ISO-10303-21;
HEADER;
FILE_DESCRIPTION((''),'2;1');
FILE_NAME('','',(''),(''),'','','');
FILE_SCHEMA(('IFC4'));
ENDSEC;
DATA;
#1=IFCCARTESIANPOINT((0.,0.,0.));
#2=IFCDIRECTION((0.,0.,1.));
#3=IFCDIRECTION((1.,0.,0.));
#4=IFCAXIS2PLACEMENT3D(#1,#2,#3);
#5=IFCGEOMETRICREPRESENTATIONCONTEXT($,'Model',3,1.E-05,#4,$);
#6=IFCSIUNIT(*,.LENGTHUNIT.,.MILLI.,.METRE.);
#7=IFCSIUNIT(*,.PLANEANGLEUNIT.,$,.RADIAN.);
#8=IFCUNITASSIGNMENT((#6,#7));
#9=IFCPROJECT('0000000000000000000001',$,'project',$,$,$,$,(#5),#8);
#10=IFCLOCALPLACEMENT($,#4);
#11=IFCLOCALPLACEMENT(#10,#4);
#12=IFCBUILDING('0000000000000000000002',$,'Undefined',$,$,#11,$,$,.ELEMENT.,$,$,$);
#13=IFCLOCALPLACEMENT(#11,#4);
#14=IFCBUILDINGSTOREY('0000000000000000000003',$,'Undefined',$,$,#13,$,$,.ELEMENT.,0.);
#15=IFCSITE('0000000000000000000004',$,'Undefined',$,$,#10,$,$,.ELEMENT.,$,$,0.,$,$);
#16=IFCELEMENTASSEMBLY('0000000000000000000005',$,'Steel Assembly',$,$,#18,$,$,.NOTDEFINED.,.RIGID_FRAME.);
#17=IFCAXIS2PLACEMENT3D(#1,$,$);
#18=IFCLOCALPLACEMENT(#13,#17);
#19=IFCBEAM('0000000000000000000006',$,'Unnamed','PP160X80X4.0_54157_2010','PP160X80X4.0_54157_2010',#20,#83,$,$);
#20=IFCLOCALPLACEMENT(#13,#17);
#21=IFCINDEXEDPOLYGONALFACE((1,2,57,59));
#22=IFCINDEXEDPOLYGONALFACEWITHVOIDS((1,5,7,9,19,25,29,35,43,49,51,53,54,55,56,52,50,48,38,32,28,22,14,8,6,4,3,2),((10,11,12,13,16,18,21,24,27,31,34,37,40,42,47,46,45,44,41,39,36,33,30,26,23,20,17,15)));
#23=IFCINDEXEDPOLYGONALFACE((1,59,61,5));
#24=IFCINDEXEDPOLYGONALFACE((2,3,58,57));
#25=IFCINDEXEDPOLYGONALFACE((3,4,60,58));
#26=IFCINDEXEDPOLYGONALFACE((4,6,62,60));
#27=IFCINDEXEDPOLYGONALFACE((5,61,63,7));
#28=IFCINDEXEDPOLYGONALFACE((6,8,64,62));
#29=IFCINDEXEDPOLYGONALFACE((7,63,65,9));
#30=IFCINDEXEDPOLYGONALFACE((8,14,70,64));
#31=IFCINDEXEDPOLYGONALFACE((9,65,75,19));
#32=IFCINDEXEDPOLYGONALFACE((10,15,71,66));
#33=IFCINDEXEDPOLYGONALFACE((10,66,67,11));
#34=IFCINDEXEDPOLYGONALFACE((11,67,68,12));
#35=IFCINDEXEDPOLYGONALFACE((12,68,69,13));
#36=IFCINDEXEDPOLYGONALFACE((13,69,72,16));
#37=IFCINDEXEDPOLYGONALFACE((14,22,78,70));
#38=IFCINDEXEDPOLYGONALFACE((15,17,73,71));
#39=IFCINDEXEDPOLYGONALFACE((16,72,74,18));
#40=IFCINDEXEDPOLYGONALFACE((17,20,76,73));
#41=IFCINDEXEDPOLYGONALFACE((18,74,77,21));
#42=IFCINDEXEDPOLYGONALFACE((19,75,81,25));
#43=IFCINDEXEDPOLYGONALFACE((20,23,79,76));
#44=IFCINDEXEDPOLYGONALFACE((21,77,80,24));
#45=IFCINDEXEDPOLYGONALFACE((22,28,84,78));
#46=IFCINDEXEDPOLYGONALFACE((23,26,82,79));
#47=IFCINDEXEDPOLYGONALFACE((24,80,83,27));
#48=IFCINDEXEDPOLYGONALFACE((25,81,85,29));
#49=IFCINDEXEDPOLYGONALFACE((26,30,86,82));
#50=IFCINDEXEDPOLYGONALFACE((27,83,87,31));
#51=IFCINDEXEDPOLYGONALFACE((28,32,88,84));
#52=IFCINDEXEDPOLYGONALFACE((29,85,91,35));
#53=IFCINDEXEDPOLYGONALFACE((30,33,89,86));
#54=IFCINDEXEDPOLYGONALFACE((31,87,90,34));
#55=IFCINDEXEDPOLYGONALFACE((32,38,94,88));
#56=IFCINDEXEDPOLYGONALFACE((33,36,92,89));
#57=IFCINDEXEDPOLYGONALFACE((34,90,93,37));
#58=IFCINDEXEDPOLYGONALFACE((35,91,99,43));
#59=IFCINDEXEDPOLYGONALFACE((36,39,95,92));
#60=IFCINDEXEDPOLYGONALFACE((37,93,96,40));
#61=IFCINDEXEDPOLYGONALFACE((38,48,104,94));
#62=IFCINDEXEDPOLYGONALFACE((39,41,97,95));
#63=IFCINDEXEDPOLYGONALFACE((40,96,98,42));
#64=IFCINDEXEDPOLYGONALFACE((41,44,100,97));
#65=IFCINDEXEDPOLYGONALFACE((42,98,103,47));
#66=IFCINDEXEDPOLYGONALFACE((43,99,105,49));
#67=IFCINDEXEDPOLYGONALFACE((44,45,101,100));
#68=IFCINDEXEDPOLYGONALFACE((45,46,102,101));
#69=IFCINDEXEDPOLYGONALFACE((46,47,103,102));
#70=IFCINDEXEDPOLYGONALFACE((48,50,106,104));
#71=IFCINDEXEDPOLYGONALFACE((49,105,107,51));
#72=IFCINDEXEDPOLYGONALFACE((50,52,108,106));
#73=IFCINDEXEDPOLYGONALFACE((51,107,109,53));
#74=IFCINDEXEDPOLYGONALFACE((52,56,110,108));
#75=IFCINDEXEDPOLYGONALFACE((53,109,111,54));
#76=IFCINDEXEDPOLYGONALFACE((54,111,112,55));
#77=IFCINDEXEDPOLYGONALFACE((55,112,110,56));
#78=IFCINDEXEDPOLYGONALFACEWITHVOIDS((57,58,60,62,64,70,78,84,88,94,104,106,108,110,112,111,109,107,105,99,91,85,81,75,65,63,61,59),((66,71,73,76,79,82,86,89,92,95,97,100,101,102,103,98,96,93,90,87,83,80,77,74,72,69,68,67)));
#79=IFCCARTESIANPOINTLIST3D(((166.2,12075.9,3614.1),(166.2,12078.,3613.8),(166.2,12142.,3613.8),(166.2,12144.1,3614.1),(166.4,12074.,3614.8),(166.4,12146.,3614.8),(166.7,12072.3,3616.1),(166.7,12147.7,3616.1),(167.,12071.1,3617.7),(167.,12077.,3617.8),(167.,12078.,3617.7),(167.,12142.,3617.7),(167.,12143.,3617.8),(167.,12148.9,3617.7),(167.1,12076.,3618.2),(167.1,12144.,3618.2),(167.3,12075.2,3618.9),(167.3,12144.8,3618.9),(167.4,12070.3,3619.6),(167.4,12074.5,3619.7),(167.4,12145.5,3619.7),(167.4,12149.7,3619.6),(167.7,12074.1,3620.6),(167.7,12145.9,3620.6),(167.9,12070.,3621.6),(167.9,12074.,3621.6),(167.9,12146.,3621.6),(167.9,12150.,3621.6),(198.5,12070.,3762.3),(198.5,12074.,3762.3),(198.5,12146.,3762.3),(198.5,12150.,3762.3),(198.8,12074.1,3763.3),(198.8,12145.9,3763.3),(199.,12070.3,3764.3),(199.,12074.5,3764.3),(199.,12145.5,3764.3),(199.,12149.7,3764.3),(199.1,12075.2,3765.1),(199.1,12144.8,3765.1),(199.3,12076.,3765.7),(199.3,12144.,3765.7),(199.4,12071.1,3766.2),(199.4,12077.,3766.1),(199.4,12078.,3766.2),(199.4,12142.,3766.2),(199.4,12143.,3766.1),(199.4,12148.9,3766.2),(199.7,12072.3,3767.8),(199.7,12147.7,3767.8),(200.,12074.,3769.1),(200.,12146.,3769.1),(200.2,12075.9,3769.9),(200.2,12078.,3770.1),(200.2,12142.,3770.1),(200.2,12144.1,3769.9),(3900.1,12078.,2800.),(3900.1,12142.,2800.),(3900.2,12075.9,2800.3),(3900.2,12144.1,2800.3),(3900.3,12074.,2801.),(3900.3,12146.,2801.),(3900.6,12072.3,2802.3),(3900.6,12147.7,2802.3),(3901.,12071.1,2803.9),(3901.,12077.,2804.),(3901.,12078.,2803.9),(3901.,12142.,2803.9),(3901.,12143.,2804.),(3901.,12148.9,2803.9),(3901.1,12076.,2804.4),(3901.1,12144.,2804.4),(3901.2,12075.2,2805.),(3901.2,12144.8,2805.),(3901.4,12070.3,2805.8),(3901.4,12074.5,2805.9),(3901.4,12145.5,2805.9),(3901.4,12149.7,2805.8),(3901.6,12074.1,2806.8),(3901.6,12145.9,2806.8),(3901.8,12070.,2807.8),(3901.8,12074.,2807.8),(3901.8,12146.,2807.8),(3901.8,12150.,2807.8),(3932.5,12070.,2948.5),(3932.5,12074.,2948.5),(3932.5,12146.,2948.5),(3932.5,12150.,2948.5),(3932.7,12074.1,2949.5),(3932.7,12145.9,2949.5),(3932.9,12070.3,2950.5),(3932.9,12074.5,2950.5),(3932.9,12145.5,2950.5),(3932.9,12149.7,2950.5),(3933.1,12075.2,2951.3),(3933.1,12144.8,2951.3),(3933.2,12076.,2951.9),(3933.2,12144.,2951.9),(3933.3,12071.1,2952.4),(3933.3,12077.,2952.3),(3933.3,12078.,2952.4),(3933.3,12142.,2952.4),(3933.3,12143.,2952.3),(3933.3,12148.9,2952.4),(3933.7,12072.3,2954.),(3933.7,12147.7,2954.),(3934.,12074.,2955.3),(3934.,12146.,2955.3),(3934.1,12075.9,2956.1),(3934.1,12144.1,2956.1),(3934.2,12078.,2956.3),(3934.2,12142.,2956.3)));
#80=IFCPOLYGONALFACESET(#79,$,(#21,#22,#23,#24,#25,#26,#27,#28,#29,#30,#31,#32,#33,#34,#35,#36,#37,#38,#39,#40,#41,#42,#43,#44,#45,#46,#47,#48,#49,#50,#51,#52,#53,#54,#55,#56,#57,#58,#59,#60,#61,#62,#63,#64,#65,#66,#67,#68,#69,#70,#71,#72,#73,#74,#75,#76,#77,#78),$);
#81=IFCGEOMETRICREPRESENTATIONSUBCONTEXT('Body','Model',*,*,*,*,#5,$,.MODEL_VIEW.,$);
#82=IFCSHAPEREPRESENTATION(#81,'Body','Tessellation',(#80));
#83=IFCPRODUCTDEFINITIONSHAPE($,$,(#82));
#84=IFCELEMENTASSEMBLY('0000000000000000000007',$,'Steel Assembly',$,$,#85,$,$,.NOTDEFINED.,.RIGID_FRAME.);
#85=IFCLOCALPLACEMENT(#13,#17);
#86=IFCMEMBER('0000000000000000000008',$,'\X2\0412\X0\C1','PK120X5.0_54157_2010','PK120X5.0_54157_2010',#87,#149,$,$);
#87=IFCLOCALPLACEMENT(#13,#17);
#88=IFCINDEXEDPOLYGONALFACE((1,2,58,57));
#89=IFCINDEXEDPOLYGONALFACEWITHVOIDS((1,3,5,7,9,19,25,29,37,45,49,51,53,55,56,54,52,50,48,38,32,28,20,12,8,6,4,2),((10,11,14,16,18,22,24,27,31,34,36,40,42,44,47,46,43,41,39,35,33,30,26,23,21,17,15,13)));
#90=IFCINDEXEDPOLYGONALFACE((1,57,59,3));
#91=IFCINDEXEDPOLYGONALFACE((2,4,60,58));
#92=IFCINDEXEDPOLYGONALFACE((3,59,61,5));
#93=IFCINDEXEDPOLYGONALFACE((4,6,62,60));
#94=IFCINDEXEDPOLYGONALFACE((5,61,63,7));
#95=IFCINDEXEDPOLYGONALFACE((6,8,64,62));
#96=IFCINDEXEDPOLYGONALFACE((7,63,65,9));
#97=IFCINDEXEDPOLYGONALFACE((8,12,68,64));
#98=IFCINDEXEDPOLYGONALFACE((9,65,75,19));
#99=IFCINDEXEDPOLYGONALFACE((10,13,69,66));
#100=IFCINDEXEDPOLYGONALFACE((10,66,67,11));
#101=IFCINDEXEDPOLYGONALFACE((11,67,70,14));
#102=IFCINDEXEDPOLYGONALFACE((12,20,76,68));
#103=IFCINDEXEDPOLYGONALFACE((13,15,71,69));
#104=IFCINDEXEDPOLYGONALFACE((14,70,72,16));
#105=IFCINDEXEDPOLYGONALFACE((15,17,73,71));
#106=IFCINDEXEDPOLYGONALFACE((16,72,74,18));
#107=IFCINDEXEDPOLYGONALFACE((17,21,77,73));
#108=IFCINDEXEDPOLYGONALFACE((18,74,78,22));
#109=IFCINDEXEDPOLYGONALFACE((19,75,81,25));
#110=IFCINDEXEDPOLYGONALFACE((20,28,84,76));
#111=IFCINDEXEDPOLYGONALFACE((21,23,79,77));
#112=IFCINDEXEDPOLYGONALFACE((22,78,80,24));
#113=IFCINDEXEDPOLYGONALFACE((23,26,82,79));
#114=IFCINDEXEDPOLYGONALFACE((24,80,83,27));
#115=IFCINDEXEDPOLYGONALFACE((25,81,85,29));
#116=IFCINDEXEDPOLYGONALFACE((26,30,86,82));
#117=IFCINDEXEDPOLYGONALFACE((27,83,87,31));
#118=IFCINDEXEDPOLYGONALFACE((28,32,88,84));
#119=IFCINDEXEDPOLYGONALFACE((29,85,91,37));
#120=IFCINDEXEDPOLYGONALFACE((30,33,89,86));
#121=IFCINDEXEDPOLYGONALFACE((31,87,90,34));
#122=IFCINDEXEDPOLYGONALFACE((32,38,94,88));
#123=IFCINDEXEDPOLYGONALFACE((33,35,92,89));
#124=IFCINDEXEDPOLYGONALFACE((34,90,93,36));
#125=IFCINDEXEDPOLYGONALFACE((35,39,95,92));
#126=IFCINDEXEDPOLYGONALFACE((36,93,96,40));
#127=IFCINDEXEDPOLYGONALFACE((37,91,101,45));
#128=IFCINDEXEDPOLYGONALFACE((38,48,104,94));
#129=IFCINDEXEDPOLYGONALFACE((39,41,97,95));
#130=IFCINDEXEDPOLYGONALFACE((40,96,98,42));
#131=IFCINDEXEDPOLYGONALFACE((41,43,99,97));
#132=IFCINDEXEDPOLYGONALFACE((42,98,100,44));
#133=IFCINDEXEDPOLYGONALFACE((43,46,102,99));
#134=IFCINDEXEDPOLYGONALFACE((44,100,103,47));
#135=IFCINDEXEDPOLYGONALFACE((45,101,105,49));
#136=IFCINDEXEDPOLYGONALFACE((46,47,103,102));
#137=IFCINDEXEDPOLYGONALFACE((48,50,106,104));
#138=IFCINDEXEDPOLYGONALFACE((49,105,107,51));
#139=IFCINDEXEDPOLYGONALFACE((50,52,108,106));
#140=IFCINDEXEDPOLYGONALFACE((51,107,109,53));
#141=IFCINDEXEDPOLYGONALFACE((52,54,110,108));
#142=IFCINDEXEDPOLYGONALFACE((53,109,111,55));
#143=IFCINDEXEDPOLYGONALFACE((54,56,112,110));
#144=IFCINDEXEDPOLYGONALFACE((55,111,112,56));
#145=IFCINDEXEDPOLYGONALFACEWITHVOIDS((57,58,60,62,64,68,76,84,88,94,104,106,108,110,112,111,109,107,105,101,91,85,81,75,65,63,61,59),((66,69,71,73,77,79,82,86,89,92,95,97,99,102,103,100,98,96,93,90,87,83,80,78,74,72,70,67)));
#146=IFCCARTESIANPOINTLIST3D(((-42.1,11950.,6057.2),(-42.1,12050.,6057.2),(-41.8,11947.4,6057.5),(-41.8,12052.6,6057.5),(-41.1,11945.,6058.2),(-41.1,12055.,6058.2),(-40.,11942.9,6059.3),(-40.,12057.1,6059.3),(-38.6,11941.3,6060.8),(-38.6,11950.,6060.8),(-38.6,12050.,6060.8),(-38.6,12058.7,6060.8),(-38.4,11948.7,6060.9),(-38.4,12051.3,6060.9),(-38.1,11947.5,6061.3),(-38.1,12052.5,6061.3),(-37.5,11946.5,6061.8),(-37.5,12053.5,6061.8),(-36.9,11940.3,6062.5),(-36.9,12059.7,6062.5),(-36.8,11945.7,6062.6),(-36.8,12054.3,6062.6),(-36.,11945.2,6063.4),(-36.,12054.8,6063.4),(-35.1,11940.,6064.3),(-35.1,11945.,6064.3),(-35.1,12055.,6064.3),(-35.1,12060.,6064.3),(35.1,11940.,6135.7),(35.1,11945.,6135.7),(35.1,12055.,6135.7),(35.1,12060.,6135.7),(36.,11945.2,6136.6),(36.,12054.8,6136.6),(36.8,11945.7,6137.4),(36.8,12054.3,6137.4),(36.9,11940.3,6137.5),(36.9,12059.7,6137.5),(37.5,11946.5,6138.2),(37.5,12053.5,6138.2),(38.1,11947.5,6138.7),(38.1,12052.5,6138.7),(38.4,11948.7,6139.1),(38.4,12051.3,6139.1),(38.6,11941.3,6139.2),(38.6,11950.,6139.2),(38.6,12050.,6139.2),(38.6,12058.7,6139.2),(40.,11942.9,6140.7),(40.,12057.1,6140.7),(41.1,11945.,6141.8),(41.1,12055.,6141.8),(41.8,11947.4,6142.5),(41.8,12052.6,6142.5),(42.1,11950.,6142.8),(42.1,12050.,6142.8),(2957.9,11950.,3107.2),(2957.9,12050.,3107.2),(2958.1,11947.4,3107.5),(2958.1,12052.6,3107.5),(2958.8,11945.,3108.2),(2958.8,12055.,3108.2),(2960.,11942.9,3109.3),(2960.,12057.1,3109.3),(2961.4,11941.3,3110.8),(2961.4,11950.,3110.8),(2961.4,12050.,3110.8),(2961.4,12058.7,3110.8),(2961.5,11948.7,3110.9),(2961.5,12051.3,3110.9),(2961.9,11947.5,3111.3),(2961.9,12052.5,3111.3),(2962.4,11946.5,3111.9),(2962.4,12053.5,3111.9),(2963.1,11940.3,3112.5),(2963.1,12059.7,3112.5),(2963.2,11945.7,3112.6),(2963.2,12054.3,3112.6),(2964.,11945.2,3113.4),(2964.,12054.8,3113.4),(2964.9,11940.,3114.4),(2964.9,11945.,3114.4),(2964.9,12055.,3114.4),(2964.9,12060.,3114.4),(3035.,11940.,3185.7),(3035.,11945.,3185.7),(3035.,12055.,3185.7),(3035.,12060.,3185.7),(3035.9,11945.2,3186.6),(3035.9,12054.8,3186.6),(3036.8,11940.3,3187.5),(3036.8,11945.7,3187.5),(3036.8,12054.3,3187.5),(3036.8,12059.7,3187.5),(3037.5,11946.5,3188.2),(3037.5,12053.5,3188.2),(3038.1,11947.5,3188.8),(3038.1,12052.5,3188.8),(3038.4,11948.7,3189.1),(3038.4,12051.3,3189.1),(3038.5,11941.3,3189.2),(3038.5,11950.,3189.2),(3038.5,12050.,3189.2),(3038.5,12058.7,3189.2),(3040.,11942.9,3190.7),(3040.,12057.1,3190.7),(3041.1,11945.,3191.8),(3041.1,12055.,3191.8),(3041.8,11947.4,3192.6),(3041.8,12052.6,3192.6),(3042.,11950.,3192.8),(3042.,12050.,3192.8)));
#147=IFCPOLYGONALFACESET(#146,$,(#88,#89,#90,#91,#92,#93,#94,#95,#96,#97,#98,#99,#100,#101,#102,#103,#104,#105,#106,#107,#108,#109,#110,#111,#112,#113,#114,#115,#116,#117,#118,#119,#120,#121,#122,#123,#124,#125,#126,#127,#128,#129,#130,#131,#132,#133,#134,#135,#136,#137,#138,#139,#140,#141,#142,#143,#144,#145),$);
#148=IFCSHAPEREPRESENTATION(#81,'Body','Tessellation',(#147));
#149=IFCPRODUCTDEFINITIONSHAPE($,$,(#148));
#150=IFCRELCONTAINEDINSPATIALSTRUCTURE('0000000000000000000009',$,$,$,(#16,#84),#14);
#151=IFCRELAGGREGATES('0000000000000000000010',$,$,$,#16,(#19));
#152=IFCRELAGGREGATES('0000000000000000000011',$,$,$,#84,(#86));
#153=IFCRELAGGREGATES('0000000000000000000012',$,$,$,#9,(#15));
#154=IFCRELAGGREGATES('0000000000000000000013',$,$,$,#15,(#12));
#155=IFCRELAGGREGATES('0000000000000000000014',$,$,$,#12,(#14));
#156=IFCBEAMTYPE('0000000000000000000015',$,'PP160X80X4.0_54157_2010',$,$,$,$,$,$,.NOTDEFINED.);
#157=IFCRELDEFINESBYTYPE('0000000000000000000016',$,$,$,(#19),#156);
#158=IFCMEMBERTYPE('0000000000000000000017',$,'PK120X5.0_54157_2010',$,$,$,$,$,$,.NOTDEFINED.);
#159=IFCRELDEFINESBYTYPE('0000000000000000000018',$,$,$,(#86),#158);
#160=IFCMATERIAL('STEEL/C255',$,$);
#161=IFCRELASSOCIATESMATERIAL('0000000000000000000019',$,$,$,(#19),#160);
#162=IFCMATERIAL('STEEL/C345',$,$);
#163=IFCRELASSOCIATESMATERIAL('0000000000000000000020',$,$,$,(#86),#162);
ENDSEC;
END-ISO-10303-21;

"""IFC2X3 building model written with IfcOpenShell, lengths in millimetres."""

from ifc_helpers import new_model, si_unit, frame, origin_with_axes, origin_2d_with_axis, place, context, subcontext, project, spatial, hollow_rectangle, extrude, material, type_object, element, aggregate, save


model = new_model("IFC2X3")

# Units and contexts
model_context = context("Model", 3, precision=1e-05, world=origin_with_axes())
body_context = subcontext(model_context, "Body", "Model", "MODEL_VIEW")
ifc_project = project(units=[si_unit("LENGTHUNIT", "METRE", prefix="MILLI"), si_unit("PLANEANGLEUNIT", "RADIAN")], contexts=[model_context])

# Site, building, storey
site_placement = place(None, origin_with_axes())
site = spatial("IfcSite", under=ifc_project, at=site_placement, Name="Undefined", CompositionType="ELEMENT", RefElevation=0.0)
building_placement = place(site_placement, origin_with_axes())
building = spatial("IfcBuilding", under=site, at=building_placement, Name="Undefined", CompositionType="ELEMENT")
storey_placement = place(building_placement, origin_with_axes())
storey = spatial("IfcBuildingStorey", under=building, at=storey_placement, Name="Undefined", CompositionType="ELEMENT", Elevation=0.0)

# Element assembly, beam
ifc_material_1 = material(Name="STEEL/C345")
assembly_1_placement = place(storey_placement, origin_with_axes())
assembly_1 = element("IfcElementAssembly", 1, at=assembly_1_placement, inside=storey, Name="Steel Assembly", AssemblyPlace="NOTDEFINED", PredefinedType="RIGID_FRAME")
ifc_material_2 = material(Name="STEEL/C255")
beam_type_1 = type_object("IfcBeamType", Name="PP160X80X4.0_54157_2010", PredefinedType="NOTDEFINED")
beam_1_placement = place(assembly_1_placement, frame((3917.1, 12110.0, 2878.2), z_axis=(0.21295, 0.0, 0.977063), x_axis=(-0.977063, 0.0, 0.21295)))
beam_1 = element("IfcBeam", 2, at=beam_1_placement, type_object=beam_type_1, material=ifc_material_2, Name="Unnamed", Description="PP160X80X4.0_54157_2010", ObjectType="PP160X80X4.0_54157_2010", context=body_context, shape_type="SweptSolid", body=[
    extrude(hollow_rectangle(XDim=80.0, YDim=160.0, WallThickness=4.0, InnerFilletRadius=4.0, OuterFilletRadius=8.0, at=origin_2d_with_axis()), frame((3821.6, 0.0, 0.0), z_axis=(-1.0, 0.0, 0.0), x_axis=(0.0, -1.0, 0.0)), (0.0, 0.0, 1.0), 3821.6),
])
aggregate(assembly_1, [beam_1])

# Element assembly, member
assembly_2_placement = place(storey_placement, origin_with_axes())
assembly_2 = element("IfcElementAssembly", 3, at=assembly_2_placement, inside=storey, Name="Steel Assembly", AssemblyPlace="NOTDEFINED", PredefinedType="RIGID_FRAME")
member_type = type_object("IfcMemberType", Name="PK120X5.0_54157_2010", PredefinedType="NOTDEFINED")
member_1_placement = place(assembly_2_placement, frame((3000.0, 12000.0, 3150.0), z_axis=(0.70114, 0.0, 0.713024), x_axis=(-0.713024, 0.0, 0.70114)))
member_1 = element("IfcMember", 4, at=member_1_placement, type_object=member_type, material=ifc_material_1, Name="ВC1", Description="PK120X5.0_54157_2010", ObjectType="PK120X5.0_54157_2010", context=body_context, shape_type="SweptSolid", body=[
    extrude(hollow_rectangle(XDim=120.0, YDim=120.0, WallThickness=5.0, InnerFilletRadius=5.0, OuterFilletRadius=10.0, at=origin_2d_with_axis()), frame((4207.4, 0.0, 0.0), z_axis=(-1.0, 0.0, 0.0), x_axis=(0.0, -1.0, 0.0)), (0.0, 0.0, 1.0), 4207.4),
])
aggregate(assembly_2, [member_1])

save(model, "model.ifc")
